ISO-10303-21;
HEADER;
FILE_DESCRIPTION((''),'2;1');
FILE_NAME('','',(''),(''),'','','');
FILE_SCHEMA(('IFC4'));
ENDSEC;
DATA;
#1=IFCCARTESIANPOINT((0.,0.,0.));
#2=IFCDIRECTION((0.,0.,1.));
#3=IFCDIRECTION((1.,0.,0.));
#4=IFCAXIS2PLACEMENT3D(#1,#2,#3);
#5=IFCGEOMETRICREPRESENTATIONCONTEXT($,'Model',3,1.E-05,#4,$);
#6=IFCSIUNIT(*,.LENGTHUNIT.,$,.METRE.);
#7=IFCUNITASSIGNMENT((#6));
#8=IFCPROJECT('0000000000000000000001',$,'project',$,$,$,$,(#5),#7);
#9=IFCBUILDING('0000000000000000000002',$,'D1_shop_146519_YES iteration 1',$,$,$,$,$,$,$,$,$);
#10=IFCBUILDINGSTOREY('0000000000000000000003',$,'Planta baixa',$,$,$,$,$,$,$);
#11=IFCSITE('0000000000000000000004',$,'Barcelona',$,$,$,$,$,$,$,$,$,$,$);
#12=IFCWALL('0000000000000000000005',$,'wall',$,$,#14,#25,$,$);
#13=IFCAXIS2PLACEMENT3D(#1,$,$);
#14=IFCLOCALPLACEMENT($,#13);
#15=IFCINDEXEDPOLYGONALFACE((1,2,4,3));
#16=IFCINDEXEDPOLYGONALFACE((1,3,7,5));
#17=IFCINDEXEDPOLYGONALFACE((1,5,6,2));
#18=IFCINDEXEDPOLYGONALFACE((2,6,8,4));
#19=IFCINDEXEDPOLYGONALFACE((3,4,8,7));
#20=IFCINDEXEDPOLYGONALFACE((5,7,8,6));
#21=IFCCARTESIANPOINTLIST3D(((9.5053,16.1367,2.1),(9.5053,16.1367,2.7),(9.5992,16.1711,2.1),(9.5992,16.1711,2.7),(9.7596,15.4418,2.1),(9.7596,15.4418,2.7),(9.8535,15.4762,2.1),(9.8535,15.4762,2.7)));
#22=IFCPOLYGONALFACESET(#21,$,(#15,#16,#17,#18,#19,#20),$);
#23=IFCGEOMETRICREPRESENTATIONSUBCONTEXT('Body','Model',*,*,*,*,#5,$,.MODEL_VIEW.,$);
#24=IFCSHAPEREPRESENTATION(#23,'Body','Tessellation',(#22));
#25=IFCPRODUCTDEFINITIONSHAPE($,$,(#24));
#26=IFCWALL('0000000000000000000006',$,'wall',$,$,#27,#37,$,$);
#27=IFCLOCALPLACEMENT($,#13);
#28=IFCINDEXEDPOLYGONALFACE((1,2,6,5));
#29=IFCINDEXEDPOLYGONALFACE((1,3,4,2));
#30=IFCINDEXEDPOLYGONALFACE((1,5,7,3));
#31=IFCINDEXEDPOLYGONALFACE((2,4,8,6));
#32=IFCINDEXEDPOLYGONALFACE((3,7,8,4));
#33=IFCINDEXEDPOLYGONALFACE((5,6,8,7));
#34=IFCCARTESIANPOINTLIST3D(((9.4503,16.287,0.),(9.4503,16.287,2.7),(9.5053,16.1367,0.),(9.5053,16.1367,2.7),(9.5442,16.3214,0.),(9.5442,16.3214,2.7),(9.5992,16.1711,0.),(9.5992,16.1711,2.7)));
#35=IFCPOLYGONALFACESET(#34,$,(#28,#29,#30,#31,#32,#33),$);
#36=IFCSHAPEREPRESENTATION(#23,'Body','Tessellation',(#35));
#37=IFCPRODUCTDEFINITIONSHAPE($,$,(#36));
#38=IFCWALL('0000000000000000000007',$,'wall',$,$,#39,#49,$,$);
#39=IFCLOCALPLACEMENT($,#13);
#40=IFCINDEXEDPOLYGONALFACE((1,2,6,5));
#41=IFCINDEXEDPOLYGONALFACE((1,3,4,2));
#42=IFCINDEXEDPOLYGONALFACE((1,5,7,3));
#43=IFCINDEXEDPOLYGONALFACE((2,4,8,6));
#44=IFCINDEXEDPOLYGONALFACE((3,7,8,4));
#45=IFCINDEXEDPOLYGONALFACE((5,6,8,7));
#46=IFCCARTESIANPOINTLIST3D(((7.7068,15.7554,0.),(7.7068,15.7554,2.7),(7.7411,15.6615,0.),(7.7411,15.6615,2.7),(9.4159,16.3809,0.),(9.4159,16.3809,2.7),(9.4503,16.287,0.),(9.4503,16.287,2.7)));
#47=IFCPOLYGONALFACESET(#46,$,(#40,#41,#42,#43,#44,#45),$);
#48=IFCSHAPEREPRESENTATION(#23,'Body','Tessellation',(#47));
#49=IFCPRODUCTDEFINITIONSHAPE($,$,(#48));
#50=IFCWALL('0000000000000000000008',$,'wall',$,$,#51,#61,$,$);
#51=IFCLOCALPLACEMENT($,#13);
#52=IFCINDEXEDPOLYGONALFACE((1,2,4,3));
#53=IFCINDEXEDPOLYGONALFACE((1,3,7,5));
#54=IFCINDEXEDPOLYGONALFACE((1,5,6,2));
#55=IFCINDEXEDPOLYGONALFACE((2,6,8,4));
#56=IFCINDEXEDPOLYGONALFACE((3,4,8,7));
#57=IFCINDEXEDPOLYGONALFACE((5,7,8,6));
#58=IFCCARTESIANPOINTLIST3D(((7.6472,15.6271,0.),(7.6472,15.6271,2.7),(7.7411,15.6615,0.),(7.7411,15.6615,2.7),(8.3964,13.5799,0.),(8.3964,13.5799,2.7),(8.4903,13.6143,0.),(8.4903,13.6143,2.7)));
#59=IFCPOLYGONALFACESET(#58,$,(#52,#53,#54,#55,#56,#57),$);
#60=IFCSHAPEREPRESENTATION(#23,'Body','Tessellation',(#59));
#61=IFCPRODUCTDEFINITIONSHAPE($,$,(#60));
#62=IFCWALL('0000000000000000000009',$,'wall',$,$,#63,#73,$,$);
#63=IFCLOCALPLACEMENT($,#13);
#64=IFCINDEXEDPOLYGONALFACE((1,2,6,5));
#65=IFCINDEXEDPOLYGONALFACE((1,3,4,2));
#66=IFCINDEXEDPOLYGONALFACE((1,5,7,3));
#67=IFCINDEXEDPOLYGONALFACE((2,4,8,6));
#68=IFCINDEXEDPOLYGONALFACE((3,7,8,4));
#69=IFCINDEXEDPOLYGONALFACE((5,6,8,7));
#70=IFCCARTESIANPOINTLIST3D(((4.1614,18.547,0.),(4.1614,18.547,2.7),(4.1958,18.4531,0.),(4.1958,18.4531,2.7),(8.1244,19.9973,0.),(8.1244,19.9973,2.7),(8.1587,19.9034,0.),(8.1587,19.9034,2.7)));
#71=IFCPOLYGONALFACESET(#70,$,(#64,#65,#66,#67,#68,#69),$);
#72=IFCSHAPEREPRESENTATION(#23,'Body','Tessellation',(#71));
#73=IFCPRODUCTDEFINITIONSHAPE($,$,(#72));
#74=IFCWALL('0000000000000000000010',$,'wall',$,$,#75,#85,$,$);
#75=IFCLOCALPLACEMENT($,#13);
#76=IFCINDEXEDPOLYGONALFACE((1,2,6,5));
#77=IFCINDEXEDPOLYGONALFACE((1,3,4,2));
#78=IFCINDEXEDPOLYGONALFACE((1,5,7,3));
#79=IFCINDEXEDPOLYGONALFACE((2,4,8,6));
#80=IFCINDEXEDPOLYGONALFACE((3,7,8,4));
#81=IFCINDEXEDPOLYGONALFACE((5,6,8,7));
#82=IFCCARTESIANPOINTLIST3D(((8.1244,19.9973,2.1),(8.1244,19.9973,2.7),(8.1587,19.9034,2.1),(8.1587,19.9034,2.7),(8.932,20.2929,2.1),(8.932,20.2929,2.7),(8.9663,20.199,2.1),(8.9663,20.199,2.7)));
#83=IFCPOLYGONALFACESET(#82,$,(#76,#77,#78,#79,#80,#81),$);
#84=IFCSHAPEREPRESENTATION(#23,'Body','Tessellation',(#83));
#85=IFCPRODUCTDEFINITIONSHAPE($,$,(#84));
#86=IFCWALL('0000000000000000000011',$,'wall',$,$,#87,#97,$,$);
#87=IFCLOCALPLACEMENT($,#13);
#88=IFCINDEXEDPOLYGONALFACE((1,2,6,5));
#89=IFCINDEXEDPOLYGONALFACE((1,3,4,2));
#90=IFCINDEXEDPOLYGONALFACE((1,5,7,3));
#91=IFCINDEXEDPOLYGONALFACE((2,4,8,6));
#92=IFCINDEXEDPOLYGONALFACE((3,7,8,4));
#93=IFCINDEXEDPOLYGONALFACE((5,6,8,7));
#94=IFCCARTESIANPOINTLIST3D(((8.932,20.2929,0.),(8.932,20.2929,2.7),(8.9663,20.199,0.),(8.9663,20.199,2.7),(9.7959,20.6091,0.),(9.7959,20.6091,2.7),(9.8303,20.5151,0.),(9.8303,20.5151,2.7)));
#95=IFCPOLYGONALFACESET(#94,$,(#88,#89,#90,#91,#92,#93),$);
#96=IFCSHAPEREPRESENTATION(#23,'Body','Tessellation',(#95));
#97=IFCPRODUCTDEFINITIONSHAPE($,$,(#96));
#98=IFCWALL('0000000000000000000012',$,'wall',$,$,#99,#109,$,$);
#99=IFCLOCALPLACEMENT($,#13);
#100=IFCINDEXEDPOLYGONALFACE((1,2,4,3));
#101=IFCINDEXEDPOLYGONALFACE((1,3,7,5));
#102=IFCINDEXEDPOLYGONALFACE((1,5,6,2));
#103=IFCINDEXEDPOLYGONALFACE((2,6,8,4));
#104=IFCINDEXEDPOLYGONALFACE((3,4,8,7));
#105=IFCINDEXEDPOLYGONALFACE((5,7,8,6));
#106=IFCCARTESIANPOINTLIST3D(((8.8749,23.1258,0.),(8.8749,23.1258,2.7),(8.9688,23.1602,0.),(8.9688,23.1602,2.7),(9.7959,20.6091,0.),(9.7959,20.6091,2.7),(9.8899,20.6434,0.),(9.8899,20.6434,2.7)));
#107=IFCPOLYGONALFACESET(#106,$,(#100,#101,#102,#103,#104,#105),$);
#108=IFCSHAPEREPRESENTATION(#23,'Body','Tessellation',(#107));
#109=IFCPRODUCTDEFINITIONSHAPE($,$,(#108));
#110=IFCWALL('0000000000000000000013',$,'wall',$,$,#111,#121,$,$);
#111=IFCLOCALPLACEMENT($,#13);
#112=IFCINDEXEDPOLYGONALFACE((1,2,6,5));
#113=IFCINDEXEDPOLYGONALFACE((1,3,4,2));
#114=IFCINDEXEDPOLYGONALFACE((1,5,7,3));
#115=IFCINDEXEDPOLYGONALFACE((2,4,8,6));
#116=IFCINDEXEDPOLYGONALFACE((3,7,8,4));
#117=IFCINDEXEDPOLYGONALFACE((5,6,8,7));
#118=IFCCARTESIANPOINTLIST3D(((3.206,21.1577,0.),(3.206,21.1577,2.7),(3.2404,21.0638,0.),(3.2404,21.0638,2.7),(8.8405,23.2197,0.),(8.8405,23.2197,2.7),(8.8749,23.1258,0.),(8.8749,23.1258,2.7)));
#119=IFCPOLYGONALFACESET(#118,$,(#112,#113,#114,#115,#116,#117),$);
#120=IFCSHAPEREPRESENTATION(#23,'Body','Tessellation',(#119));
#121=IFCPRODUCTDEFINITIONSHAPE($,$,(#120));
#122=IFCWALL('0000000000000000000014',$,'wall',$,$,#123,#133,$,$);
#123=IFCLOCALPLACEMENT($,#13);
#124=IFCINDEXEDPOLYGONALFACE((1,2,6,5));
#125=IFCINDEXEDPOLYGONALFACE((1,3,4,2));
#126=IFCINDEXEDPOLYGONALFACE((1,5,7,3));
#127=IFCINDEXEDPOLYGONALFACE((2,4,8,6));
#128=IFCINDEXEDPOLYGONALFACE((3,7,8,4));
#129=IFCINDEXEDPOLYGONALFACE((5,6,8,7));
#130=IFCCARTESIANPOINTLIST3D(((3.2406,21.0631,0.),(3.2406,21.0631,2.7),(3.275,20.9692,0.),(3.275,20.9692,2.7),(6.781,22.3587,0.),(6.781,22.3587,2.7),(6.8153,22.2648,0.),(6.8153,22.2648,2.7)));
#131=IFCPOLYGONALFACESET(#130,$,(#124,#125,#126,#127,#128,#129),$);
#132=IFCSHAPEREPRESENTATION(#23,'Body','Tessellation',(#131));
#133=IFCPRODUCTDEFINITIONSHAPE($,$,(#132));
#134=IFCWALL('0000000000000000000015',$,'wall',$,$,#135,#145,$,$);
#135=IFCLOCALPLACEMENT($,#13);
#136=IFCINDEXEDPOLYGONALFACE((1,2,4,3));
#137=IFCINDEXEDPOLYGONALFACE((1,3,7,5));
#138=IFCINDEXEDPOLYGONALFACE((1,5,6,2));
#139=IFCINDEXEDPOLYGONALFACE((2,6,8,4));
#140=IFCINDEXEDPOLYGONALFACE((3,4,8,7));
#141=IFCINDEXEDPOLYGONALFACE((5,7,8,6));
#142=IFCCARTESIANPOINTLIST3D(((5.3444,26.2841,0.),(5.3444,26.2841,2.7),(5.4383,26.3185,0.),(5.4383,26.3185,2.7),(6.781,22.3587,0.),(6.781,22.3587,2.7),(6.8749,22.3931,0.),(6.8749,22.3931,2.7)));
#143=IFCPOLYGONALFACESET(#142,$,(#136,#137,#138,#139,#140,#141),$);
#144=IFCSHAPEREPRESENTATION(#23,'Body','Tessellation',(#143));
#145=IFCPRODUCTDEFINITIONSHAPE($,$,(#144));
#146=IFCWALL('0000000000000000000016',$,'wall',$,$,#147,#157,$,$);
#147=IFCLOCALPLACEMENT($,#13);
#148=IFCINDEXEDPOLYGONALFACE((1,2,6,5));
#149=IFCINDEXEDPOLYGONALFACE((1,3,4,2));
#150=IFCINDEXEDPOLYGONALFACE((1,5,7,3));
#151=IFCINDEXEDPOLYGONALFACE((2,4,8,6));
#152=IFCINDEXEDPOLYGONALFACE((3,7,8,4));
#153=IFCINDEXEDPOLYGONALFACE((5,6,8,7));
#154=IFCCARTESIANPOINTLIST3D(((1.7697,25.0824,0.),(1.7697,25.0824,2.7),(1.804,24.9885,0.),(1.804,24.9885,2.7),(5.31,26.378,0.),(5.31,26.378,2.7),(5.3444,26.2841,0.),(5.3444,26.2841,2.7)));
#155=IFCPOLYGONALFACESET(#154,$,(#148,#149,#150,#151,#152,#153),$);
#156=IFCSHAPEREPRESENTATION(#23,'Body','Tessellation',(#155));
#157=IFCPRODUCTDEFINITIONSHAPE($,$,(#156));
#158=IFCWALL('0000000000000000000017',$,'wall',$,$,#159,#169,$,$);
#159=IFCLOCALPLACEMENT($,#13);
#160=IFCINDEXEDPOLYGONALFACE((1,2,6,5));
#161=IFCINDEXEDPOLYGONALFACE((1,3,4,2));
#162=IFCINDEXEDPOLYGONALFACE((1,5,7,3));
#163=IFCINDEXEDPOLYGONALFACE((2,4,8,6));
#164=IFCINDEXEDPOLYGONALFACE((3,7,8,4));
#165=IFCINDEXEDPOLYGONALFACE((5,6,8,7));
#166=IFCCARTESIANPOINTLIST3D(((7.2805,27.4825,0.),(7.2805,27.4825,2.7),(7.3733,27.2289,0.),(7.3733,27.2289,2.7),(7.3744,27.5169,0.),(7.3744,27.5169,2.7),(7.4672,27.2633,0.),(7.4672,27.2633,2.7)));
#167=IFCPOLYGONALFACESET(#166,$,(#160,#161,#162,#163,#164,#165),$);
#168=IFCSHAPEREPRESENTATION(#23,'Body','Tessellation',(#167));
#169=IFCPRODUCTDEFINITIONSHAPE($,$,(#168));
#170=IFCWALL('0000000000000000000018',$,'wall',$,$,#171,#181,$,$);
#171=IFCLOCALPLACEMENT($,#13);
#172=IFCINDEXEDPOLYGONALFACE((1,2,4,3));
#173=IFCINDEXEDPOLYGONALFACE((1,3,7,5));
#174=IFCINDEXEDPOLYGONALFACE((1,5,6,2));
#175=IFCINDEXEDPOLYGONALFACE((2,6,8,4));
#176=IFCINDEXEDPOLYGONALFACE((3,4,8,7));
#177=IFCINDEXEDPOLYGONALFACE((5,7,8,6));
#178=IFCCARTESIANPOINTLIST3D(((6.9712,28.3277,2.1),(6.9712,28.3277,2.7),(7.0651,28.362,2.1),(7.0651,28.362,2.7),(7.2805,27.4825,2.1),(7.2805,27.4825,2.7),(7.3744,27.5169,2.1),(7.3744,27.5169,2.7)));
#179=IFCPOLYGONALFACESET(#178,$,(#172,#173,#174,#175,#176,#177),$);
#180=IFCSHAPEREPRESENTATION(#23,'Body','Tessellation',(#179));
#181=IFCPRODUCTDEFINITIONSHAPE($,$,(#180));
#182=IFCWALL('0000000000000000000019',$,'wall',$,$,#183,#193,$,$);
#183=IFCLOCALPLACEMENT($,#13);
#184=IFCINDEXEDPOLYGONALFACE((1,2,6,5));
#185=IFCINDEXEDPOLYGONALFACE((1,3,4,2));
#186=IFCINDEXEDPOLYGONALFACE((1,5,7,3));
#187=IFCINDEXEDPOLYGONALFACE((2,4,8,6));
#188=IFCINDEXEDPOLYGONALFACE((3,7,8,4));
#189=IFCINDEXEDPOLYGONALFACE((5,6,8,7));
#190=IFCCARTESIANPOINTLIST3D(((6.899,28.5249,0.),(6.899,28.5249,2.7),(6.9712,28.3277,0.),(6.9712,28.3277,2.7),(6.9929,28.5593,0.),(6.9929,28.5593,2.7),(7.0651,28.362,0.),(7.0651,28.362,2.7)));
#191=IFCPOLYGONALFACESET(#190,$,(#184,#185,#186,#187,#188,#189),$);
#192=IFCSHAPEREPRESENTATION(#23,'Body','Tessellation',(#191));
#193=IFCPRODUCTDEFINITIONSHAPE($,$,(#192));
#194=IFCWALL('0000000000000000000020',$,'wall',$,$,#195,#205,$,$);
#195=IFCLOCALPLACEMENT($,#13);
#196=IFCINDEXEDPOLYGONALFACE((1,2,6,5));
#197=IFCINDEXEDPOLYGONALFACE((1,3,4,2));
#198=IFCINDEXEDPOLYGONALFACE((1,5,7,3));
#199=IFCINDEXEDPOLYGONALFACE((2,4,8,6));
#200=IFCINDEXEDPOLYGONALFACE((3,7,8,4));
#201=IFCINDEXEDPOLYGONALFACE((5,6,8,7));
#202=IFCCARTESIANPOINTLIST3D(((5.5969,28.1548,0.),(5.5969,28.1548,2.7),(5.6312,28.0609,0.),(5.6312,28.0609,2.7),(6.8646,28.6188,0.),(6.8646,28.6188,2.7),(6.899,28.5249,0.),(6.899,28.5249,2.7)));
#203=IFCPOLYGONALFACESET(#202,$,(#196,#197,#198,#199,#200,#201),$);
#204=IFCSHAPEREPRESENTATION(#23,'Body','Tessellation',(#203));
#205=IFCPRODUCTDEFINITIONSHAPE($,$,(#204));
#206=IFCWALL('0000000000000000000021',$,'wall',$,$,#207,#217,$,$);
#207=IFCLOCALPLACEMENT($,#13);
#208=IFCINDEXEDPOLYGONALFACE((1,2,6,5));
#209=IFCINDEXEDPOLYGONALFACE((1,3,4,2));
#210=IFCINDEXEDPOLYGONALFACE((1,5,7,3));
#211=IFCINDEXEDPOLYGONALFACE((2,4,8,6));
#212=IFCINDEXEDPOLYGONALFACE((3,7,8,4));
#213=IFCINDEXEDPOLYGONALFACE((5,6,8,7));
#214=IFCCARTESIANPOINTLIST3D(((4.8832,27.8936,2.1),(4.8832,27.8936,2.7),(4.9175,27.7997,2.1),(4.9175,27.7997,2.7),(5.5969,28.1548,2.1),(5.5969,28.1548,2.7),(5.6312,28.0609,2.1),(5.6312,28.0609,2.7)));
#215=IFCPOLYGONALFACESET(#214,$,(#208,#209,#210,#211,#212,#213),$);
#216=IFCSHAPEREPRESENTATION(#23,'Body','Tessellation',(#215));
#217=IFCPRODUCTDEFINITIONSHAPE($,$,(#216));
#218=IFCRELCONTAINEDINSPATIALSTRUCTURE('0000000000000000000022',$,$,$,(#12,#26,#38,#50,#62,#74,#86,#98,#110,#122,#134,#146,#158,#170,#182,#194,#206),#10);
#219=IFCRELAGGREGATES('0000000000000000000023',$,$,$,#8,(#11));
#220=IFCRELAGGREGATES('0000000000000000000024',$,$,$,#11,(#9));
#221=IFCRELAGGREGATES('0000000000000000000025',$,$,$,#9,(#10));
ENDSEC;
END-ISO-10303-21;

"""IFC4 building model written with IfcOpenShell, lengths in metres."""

from ifc_helpers import new_model, si_unit, frame, origin, origin_with_axes, place, context, subcontext, project, spatial, polyline, outline, extrude, element, save


model = new_model("IFC4")

# Units and contexts
model_context = context("Model", 3, precision=1e-05, world=origin_with_axes())
body_context = subcontext(model_context, "Body", "Model", "MODEL_VIEW")
ifc_project = project(units=[si_unit("LENGTHUNIT", "METRE")], contexts=[model_context])

# Site, building, storey
site = spatial("IfcSite", under=ifc_project, Name="Barcelona")
building = spatial("IfcBuilding", under=site, Name="D1_shop_146519_YES iteration 1")
storey = spatial("IfcBuildingStorey", under=building, Name="Planta baixa")

# Walls
wall_1_placement = place(None, origin_with_axes())
element("IfcWall", 1, at=wall_1_placement, inside=storey, Name="wall", context=body_context, shape_type="SweptSolid", body=[
    extrude(outline(polyline([(9.7596, 15.4418), (9.5053, 16.1367), (9.5992, 16.1711), (9.8535, 15.4762), (9.7596, 15.4418)])), frame((0.0, 0.0, 2.1)), (0.0, 0.0, 1.0), 0.6),
])
wall_2_placement = place(None, origin_with_axes())
element("IfcWall", 2, at=wall_2_placement, inside=storey, Name="wall", context=body_context, shape_type="SweptSolid", body=[
    extrude(outline(polyline([(9.5053, 16.1367), (9.4503, 16.287), (9.5442, 16.3214), (9.5992, 16.1711), (9.5053, 16.1367)])), origin(), (0.0, 0.0, 1.0), 2.7),
])
wall_3_placement = place(None, origin_with_axes())
element("IfcWall", 3, at=wall_3_placement, inside=storey, Name="wall", context=body_context, shape_type="SweptSolid", body=[
    extrude(outline(polyline([(9.4503, 16.287), (7.7411, 15.6615), (7.7068, 15.7554), (9.4159, 16.3809), (9.4503, 16.287)])), origin(), (0.0, 0.0, 1.0), 2.7),
])
wall_4_placement = place(None, origin_with_axes())
element("IfcWall", 4, at=wall_4_placement, inside=storey, Name="wall", context=body_context, shape_type="SweptSolid", body=[
    extrude(outline(polyline([(7.7411, 15.6615), (8.4903, 13.6143), (8.3964, 13.5799), (7.6472, 15.6271), (7.7411, 15.6615)])), origin(), (0.0, 0.0, 1.0), 2.7),
])
wall_5_placement = place(None, origin_with_axes())
element("IfcWall", 5, at=wall_5_placement, inside=storey, Name="wall", context=body_context, shape_type="SweptSolid", body=[
    extrude(outline(polyline([(4.1614, 18.547), (8.1244, 19.9973), (8.1587, 19.9034), (4.1958, 18.4531), (4.1614, 18.547)])), origin(), (0.0, 0.0, 1.0), 2.7),
])
wall_6_placement = place(None, origin_with_axes())
element("IfcWall", 6, at=wall_6_placement, inside=storey, Name="wall", context=body_context, shape_type="SweptSolid", body=[
    extrude(outline(polyline([(8.1244, 19.9973), (8.932, 20.2929), (8.9663, 20.199), (8.1587, 19.9034), (8.1244, 19.9973)])), frame((0.0, 0.0, 2.1)), (0.0, 0.0, 1.0), 0.6),
])
wall_7_placement = place(None, origin_with_axes())
element("IfcWall", 7, at=wall_7_placement, inside=storey, Name="wall", context=body_context, shape_type="SweptSolid", body=[
    extrude(outline(polyline([(8.932, 20.2929), (9.7959, 20.6091), (9.8303, 20.5151), (8.9663, 20.199), (8.932, 20.2929)])), origin(), (0.0, 0.0, 1.0), 2.7),
])
wall_8_placement = place(None, origin_with_axes())
element("IfcWall", 8, at=wall_8_placement, inside=storey, Name="wall", context=body_context, shape_type="SweptSolid", body=[
    extrude(outline(polyline([(9.7959, 20.6091), (8.8749, 23.1258), (8.9688, 23.1602), (9.8899, 20.6434), (9.7959, 20.6091)])), origin(), (0.0, 0.0, 1.0), 2.7),
])
wall_9_placement = place(None, origin_with_axes())
element("IfcWall", 9, at=wall_9_placement, inside=storey, Name="wall", context=body_context, shape_type="SweptSolid", body=[
    extrude(outline(polyline([(8.8749, 23.1258), (3.2404, 21.0638), (3.206, 21.1577), (8.8405, 23.2197), (8.8749, 23.1258)])), origin(), (0.0, 0.0, 1.0), 2.7),
])
wall_10_placement = place(None, origin_with_axes())
element("IfcWall", 10, at=wall_10_placement, inside=storey, Name="wall", context=body_context, shape_type="SweptSolid", body=[
    extrude(outline(polyline([(3.2406, 21.0631), (6.781, 22.3587), (6.8153, 22.2648), (3.275, 20.9692), (3.2406, 21.0631)])), origin(), (0.0, 0.0, 1.0), 2.7),
])
wall_11_placement = place(None, origin_with_axes())
element("IfcWall", 11, at=wall_11_placement, inside=storey, Name="wall", context=body_context, shape_type="SweptSolid", body=[
    extrude(outline(polyline([(6.781, 22.3587), (5.3444, 26.2841), (5.4383, 26.3185), (6.8749, 22.3931), (6.781, 22.3587)])), origin(), (0.0, 0.0, 1.0), 2.7),
])
wall_12_placement = place(None, origin_with_axes())
element("IfcWall", 12, at=wall_12_placement, inside=storey, Name="wall", context=body_context, shape_type="SweptSolid", body=[
    extrude(outline(polyline([(5.3444, 26.2841), (1.804, 24.9885), (1.7697, 25.0824), (5.31, 26.378), (5.3444, 26.2841)])), origin(), (0.0, 0.0, 1.0), 2.7),
])
wall_13_placement = place(None, origin_with_axes())
element("IfcWall", 13, at=wall_13_placement, inside=storey, Name="wall", context=body_context, shape_type="SweptSolid", body=[
    extrude(outline(polyline([(7.3733, 27.2289), (7.2805, 27.4825), (7.3744, 27.5169), (7.4672, 27.2633), (7.3733, 27.2289)])), origin(), (0.0, 0.0, 1.0), 2.7),
])
wall_14_placement = place(None, origin_with_axes())
element("IfcWall", 14, at=wall_14_placement, inside=storey, Name="wall", context=body_context, shape_type="SweptSolid", body=[
    extrude(outline(polyline([(7.2805, 27.4825), (6.9712, 28.3277), (7.0651, 28.362), (7.3744, 27.5169), (7.2805, 27.4825)])), frame((0.0, 0.0, 2.1)), (0.0, 0.0, 1.0), 0.6),
])
wall_15_placement = place(None, origin_with_axes())
element("IfcWall", 15, at=wall_15_placement, inside=storey, Name="wall", context=body_context, shape_type="SweptSolid", body=[
    extrude(outline(polyline([(6.9712, 28.3277), (6.899, 28.5249), (6.9929, 28.5593), (7.0651, 28.362), (6.9712, 28.3277)])), origin(), (0.0, 0.0, 1.0), 2.7),
])
wall_16_placement = place(None, origin_with_axes())
element("IfcWall", 16, at=wall_16_placement, inside=storey, Name="wall", context=body_context, shape_type="SweptSolid", body=[
    extrude(outline(polyline([(6.899, 28.5249), (5.6312, 28.0609), (5.5969, 28.1548), (6.8646, 28.6188), (6.899, 28.5249)])), origin(), (0.0, 0.0, 1.0), 2.7),
])
wall_17_placement = place(None, origin_with_axes())
element("IfcWall", 17, at=wall_17_placement, inside=storey, Name="wall", context=body_context, shape_type="SweptSolid", body=[
    extrude(outline(polyline([(5.6312, 28.0609), (4.9175, 27.7997), (4.8832, 27.8936), (5.5969, 28.1548), (5.6312, 28.0609)])), frame((0.0, 0.0, 2.1)), (0.0, 0.0, 1.0), 0.6),
])

save(model, "model.ifc")
